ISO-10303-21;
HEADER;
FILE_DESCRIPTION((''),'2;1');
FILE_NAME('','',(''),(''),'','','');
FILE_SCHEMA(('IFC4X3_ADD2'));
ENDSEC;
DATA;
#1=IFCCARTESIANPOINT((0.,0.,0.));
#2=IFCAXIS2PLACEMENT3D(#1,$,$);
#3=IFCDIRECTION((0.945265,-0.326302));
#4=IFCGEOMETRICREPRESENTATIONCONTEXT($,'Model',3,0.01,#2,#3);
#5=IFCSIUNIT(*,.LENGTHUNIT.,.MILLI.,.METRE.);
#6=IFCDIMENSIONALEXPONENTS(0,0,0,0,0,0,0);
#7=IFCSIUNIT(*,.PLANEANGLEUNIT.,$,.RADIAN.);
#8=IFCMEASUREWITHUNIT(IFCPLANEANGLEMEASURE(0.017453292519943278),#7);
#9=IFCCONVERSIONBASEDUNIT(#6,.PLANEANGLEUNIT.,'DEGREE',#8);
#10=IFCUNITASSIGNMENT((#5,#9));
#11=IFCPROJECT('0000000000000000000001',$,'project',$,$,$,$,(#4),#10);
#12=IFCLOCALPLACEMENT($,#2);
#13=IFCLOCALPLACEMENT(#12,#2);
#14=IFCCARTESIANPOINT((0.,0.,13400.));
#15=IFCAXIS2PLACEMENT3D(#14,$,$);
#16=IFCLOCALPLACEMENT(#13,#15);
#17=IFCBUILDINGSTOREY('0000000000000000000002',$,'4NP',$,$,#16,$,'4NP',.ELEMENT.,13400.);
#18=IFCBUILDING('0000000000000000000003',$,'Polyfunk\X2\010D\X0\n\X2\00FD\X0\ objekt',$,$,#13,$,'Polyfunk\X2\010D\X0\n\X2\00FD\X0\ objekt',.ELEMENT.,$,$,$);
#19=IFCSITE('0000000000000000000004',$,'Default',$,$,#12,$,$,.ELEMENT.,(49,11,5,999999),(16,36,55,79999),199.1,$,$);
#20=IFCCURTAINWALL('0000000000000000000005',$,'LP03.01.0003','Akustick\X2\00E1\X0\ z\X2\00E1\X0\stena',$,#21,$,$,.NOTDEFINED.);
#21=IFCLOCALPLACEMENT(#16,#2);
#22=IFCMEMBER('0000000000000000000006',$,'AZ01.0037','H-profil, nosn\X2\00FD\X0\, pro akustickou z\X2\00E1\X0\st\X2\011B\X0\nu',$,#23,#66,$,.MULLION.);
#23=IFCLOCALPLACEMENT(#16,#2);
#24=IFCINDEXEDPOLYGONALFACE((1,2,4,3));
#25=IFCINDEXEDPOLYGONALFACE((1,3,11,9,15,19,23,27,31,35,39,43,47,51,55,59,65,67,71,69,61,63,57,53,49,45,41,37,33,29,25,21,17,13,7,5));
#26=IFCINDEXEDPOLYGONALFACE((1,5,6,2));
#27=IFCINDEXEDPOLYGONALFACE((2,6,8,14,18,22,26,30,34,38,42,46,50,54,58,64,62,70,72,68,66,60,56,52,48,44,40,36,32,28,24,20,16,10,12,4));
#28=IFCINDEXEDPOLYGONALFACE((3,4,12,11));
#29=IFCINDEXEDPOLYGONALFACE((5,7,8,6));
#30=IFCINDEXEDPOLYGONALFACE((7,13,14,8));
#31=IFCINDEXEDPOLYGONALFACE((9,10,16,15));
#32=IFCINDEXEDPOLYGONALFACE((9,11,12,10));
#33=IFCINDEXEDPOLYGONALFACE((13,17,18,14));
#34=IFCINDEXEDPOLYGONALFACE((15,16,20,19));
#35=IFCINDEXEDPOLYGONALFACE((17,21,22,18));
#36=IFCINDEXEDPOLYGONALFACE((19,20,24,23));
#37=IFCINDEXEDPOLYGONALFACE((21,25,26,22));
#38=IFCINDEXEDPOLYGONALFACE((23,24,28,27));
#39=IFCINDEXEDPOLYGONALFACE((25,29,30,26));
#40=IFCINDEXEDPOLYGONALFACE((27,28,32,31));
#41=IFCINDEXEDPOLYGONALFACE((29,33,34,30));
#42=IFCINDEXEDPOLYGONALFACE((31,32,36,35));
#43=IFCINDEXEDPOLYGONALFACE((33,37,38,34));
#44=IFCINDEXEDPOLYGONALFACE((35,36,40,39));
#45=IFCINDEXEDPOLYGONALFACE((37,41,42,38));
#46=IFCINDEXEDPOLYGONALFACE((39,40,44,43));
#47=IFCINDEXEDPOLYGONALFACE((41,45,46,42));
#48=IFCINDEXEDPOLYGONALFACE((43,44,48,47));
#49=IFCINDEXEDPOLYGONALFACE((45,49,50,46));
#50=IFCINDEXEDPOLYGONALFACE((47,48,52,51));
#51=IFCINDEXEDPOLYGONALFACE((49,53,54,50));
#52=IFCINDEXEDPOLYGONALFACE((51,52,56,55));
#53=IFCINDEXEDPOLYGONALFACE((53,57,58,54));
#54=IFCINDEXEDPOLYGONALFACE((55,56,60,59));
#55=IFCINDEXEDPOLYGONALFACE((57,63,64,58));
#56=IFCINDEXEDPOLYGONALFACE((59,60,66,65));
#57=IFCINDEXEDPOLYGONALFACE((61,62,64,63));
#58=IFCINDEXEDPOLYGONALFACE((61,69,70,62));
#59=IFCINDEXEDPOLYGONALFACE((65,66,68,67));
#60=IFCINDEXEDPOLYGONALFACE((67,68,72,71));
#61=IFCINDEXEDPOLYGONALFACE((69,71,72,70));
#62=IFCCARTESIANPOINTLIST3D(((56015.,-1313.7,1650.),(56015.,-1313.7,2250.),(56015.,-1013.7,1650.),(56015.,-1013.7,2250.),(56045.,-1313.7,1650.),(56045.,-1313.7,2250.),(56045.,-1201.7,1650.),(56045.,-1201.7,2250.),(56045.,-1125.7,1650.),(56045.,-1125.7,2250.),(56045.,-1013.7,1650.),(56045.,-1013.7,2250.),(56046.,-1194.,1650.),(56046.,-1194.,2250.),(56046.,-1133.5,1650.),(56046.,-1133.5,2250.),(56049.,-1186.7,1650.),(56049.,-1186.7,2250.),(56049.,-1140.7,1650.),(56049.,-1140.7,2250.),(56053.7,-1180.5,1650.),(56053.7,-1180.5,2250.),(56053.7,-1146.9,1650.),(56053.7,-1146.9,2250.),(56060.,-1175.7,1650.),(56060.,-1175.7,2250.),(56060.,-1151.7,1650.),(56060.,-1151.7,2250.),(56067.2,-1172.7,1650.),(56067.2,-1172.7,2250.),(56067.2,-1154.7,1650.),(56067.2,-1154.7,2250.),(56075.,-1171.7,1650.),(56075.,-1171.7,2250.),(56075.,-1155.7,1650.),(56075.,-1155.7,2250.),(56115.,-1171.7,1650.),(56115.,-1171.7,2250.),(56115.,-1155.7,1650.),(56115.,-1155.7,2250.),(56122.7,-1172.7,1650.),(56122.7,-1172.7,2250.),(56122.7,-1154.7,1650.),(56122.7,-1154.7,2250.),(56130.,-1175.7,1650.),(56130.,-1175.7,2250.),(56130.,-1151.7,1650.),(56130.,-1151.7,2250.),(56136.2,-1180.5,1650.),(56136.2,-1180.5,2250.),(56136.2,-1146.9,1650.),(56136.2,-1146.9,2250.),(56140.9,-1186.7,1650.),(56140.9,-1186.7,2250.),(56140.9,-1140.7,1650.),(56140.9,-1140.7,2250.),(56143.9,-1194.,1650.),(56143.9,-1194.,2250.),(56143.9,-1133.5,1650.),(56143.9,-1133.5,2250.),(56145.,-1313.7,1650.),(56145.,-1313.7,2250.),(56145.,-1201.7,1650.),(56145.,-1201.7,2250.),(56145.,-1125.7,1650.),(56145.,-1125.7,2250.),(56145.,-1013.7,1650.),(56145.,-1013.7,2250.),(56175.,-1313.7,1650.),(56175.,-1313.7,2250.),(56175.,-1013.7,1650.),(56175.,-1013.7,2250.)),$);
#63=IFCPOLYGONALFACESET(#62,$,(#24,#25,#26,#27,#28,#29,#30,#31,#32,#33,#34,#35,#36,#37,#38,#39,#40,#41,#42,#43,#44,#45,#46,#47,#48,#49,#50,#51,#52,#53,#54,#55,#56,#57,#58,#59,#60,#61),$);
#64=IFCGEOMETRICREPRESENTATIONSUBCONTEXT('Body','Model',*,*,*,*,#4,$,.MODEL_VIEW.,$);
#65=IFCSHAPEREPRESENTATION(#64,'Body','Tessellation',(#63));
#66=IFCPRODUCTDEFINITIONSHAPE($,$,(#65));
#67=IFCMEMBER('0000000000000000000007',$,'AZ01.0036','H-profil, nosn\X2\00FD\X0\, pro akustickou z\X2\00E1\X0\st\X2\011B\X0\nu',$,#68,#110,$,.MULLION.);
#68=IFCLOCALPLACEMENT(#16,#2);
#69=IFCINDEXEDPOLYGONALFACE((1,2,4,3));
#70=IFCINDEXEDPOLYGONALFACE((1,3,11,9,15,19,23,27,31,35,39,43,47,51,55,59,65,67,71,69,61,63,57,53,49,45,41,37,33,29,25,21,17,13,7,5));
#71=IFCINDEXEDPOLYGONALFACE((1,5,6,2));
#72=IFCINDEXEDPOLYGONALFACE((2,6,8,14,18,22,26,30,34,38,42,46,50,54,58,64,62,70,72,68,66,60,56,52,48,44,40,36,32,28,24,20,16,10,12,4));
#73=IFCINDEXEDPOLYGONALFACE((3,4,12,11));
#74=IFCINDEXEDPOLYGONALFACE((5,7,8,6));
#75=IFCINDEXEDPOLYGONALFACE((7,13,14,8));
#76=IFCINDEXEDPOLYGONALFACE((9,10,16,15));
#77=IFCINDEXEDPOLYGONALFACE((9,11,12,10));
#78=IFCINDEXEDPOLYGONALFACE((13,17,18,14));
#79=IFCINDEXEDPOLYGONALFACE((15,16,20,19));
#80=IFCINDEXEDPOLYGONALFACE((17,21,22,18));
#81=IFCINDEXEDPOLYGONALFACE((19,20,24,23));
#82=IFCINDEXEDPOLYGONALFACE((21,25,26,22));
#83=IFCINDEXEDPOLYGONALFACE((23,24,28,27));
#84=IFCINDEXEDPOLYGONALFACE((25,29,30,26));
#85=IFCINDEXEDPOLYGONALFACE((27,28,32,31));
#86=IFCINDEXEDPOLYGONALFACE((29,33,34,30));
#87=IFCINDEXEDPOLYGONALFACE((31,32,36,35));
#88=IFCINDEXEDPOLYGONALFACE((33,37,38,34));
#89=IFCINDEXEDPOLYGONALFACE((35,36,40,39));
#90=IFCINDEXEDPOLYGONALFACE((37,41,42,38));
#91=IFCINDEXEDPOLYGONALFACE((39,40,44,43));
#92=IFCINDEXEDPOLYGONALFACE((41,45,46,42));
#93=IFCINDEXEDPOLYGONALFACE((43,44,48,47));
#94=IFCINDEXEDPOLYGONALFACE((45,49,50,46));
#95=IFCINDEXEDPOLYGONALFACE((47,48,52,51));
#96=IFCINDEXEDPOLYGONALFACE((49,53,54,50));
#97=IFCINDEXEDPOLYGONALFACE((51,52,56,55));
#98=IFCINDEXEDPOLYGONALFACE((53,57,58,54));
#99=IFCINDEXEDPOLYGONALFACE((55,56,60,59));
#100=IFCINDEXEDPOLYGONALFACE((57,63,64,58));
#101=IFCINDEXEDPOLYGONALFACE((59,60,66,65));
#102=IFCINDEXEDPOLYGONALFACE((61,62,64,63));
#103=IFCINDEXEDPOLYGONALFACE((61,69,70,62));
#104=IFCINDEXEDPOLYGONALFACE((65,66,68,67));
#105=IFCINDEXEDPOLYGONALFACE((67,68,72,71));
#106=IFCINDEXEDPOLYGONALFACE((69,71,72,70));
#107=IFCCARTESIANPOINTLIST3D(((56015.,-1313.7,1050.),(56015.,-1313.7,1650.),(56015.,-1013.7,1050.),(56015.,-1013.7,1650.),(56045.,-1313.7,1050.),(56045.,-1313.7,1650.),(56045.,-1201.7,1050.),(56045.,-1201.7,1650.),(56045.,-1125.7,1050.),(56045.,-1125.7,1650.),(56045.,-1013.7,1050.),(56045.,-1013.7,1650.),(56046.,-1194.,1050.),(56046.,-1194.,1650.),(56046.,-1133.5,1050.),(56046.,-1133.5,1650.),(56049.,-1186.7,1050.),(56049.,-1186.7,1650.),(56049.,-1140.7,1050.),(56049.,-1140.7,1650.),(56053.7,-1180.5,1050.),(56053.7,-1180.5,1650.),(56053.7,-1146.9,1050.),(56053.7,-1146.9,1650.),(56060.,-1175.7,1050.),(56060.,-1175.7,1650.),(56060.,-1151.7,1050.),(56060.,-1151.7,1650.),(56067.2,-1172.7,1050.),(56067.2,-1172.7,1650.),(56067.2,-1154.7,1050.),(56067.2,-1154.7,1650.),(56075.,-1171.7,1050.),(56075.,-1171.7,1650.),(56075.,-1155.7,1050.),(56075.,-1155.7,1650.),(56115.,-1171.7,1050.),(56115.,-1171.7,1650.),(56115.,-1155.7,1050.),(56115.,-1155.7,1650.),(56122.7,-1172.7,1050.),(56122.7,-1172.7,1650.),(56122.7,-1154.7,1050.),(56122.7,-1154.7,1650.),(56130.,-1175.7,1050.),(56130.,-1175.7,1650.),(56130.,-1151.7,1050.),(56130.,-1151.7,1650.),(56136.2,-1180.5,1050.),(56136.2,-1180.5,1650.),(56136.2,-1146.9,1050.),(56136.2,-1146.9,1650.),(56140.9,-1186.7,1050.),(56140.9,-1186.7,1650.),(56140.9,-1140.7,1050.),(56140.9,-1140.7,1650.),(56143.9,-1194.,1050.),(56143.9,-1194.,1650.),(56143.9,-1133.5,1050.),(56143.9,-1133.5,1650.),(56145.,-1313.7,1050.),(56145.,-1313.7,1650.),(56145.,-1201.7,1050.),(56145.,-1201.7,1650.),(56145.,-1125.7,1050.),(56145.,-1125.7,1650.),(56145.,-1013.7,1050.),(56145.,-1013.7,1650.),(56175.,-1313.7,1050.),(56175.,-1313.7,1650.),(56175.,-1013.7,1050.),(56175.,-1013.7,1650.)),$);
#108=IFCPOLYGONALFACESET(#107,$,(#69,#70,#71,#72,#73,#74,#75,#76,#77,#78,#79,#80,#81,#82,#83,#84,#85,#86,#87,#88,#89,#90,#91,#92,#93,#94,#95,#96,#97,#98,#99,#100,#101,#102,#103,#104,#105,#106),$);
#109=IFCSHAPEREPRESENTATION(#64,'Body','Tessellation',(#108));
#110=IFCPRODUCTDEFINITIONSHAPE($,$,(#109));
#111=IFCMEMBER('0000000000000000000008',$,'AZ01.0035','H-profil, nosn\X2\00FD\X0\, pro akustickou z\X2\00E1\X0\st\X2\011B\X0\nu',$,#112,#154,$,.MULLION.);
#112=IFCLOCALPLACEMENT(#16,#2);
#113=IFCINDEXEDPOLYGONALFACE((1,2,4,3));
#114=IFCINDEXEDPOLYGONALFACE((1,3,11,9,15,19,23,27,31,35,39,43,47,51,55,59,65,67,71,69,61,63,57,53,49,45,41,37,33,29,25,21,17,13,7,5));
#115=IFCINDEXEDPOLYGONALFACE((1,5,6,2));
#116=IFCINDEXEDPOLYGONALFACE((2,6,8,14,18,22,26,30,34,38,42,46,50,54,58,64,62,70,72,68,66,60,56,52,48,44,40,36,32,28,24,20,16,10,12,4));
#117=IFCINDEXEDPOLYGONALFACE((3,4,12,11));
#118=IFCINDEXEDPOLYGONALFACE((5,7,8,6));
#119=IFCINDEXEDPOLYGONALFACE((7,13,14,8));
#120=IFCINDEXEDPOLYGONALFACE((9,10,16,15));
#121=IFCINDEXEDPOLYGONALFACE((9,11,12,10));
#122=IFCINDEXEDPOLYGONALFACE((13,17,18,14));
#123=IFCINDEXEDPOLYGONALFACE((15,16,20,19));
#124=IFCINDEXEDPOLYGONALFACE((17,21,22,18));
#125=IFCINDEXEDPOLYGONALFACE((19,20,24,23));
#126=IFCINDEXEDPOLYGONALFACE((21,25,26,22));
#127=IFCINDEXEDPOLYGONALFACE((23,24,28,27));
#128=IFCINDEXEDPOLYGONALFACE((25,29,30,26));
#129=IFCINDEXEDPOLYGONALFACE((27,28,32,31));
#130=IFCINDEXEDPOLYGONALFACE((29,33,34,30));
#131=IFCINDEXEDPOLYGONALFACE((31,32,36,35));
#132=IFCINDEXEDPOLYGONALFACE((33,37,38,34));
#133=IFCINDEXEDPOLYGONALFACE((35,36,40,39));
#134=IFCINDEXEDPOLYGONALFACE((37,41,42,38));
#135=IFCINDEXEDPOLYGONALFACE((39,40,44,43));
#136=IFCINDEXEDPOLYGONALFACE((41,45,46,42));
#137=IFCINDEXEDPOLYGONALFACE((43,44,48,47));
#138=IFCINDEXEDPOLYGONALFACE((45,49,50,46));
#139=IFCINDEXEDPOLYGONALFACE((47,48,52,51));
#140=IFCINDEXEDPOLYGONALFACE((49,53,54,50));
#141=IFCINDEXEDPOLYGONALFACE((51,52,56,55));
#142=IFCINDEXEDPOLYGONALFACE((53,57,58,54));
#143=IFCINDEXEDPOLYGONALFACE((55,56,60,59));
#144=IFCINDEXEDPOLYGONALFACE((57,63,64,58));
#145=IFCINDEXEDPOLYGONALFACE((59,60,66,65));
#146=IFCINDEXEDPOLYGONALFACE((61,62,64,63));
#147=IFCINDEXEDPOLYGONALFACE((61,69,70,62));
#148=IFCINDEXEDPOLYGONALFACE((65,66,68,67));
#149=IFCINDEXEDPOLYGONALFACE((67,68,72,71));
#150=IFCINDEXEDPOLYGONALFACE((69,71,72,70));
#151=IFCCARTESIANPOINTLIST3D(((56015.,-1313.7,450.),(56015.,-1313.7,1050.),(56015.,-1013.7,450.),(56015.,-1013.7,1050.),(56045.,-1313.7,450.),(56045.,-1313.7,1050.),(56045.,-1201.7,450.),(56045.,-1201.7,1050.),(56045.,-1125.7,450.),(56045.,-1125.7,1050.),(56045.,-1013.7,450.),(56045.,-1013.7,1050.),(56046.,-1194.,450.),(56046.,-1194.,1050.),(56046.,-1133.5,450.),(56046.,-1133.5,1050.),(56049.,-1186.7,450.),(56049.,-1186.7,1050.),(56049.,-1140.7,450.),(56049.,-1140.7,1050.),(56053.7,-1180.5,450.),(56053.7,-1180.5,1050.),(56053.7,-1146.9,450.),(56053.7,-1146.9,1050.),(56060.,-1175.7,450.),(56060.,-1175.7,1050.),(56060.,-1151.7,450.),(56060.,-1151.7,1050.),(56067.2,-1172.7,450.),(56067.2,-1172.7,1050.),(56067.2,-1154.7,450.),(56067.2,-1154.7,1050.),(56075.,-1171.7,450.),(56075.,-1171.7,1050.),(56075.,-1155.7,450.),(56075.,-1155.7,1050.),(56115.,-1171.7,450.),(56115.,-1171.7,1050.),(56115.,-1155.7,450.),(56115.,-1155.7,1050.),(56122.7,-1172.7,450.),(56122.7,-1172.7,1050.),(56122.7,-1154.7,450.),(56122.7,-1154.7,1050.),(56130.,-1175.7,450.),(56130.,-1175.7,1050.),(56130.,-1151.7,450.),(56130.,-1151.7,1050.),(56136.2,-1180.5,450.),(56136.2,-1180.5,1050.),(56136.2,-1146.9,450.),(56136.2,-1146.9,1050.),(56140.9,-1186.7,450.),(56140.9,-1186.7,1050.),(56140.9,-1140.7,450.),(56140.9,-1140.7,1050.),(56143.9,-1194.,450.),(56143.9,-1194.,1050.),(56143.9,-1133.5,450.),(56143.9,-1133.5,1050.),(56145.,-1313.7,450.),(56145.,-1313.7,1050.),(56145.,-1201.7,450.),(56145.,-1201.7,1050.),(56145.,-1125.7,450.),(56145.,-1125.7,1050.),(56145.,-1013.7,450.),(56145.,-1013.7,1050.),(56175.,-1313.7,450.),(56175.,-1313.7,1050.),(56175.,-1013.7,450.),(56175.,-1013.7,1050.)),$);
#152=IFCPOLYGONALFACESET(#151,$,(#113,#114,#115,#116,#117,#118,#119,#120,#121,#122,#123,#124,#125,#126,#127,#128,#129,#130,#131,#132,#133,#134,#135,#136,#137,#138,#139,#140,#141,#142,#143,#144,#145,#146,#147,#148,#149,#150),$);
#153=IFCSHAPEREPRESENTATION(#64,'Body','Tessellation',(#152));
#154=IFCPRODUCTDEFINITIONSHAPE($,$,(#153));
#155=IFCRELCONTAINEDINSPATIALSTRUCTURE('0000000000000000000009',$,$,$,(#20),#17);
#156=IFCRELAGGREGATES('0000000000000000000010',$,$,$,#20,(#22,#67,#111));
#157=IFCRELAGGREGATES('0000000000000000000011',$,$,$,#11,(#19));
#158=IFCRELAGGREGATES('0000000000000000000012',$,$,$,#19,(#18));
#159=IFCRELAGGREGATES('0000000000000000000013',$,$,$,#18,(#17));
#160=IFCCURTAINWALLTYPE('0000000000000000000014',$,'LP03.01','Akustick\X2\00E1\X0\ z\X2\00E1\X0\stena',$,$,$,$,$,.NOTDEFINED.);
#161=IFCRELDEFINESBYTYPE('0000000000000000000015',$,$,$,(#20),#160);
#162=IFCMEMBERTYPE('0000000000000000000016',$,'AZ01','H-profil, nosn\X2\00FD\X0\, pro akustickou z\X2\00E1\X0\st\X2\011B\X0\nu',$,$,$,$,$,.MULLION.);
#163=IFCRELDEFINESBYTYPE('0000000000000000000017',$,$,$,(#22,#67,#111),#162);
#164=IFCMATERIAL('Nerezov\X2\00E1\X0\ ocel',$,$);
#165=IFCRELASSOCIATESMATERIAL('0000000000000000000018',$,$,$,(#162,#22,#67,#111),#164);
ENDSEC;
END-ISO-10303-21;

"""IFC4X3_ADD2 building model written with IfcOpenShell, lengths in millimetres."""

from ifc_helpers import new_model, entity, si_unit, converted_unit, direction, frame, frame_2d, origin, place, context, subcontext, project, spatial, polyline, circle_curve, parameter, trimmed, segment, composite_curve, outline, extrude, source, transform, mapped, material, material_profile, profile_set, profile_usage, type_object, element, aggregate, save


model = new_model("IFC4X3_ADD2")

# Units and contexts
model_context = context("Model", 3, precision=0.01, world=origin(), true_north=direction((0.945265, -0.326302)))
body_context = subcontext(model_context, "Body", "Model", "MODEL_VIEW")
ifc_project = project(units=[si_unit("LENGTHUNIT", "METRE", prefix="MILLI"), converted_unit("PLANEANGLEUNIT", "DEGREE", entity("IfcPlaneAngleMeasure", 0.017453292519943278), si_unit("PLANEANGLEUNIT", "RADIAN"), dimensions=[0, 0, 0, 0, 0, 0, 0])], contexts=[model_context])

# Site, building, storey
site_placement = place(None, origin())
site = spatial("IfcSite", under=ifc_project, at=site_placement, Name="Default", CompositionType="ELEMENT", RefLatitude=(49, 11, 5, 999999), RefLongitude=(16, 36, 55, 79999), RefElevation=199.1)
building_placement = place(site_placement, origin())
building = spatial("IfcBuilding", under=site, at=building_placement, Name="Polyfunkčný objekt", LongName="Polyfunkčný objekt", CompositionType="ELEMENT")
storey_placement = place(building_placement, frame((0.0, 0.0, 13400.0)))
storey = spatial("IfcBuildingStorey", under=building, at=storey_placement, Name="4NP", LongName="4NP", CompositionType="ELEMENT", Elevation=13400.0)

# Curtain wall, members
curtain_wall_type = type_object("IfcCurtainWallType", Name="LP03.01", Description="Akustická zástena", PredefinedType="NOTDEFINED")
curtain_wall_1_placement = place(storey_placement, frame((0.0, 0.0, -13400.0)))
curtain_wall_1 = element("IfcCurtainWall", 1, at=curtain_wall_1_placement, inside=storey, type_object=curtain_wall_type, Name="LP03.01.0003", Description="Akustická zástena", PredefinedType="NOTDEFINED")
ifc_material_1 = material(Name="Nerezová ocel")
ifc_material_profile = material_profile(ifc_material_1, outline(composite_curve([segment(polyline([(50.0, -150.0), (80.0, -150.0)]), True, "CONTINUOUS"), segment(polyline([(80.0, -150.0), (80.0, 150.0)]), True, "CONTINUOUS"), segment(polyline([(80.0, 150.0), (50.0, 150.0)]), True, "CONTINUOUS"), segment(polyline([(50.0, 150.0), (50.0, 38.0)]), True, "CONTINUOUS"), segment(trimmed(circle_curve(frame_2d((20.0, 38.0), x_axis=(0.0, 1.0)), 30.0), [parameter(180.0)], [parameter(270.0)], True, "PARAMETER"), False, "CONTINUOUS"), segment(polyline([(20.0, 8.0), (-20.0, 8.0)]), True, "CONTINUOUS"), segment(trimmed(circle_curve(frame_2d((-20.0, 38.0), x_axis=(0.0, 1.0)), 30.0), [parameter(90.0)], [parameter(180.0)], True, "PARAMETER"), False, "CONTINUOUS"), segment(polyline([(-50.0, 38.0), (-50.0, 150.0)]), True, "CONTINUOUS"), segment(polyline([(-50.0, 150.0), (-80.0, 150.0)]), True, "CONTINUOUS"), segment(polyline([(-80.0, 150.0), (-80.0, -150.0)]), True, "CONTINUOUS"), segment(polyline([(-80.0, -150.0), (-50.0, -150.0)]), True, "CONTINUOUS"), segment(polyline([(-50.0, -150.0), (-50.0, -38.0)]), True, "CONTINUOUS"), segment(trimmed(circle_curve(frame_2d((-20.0, -38.0), x_axis=(0.0, 1.0)), 30.0), [parameter(0.0)], [parameter(90.0)], True, "PARAMETER"), False, "CONTINUOUS"), segment(polyline([(-20.0, -8.0), (20.0, -8.0)]), True, "CONTINUOUS"), segment(trimmed(circle_curve(frame_2d((20.0, -38.0), x_axis=(0.0, 1.0)), 30.0), [parameter(270.0)], [parameter(0.0)], True, "PARAMETER"), False, "CONTINUOUS"), segment(polyline([(50.0, -38.0), (50.0, -150.0)]), True, "CONTINUOUS")], self_intersect=False)), Name="Profil zástena")
ifc_profile_set = profile_set([ifc_material_profile], Name="Profil zástena")
ifc_profile_usage = profile_usage(ifc_profile_set)
member_type = type_object("IfcMemberType", Name="AZ01", Description="H-profil, nosný, pro akustickou zástěnu", PredefinedType="MULLION", material=ifc_profile_set)
shared_shape_1 = source(origin(), body_context, "Body", "SweptSolid", [
    extrude(outline(composite_curve([segment(polyline([(50.0, -150.0), (80.0, -150.0)]), True, "CONTINUOUS"), segment(polyline([(80.0, -150.0), (80.0, 150.0)]), True, "CONTINUOUS"), segment(polyline([(80.0, 150.0), (50.0, 150.0)]), True, "CONTINUOUS"), segment(polyline([(50.0, 150.0), (50.0, 38.0)]), True, "CONTINUOUS"), segment(trimmed(circle_curve(frame_2d((20.0, 38.0), x_axis=(0.0, 1.0)), 30.0), [parameter(180.0)], [parameter(270.0)], True, "PARAMETER"), False, "CONTINUOUS"), segment(polyline([(20.0, 8.0), (-20.0, 8.0)]), True, "CONTINUOUS"), segment(trimmed(circle_curve(frame_2d((-20.0, 38.0), x_axis=(0.0, 1.0)), 30.0), [parameter(90.0)], [parameter(180.0)], True, "PARAMETER"), False, "CONTINUOUS"), segment(polyline([(-50.0, 38.0), (-50.0, 150.0)]), True, "CONTINUOUS"), segment(polyline([(-50.0, 150.0), (-80.0, 150.0)]), True, "CONTINUOUS"), segment(polyline([(-80.0, 150.0), (-80.0, -150.0)]), True, "CONTINUOUS"), segment(polyline([(-80.0, -150.0), (-50.0, -150.0)]), True, "CONTINUOUS"), segment(polyline([(-50.0, -150.0), (-50.0, -38.0)]), True, "CONTINUOUS"), segment(trimmed(circle_curve(frame_2d((-20.0, -38.0), x_axis=(0.0, 1.0)), 30.0), [parameter(0.0)], [parameter(90.0)], True, "PARAMETER"), False, "CONTINUOUS"), segment(polyline([(-20.0, -8.0), (20.0, -8.0)]), True, "CONTINUOUS"), segment(trimmed(circle_curve(frame_2d((20.0, -38.0), x_axis=(0.0, 1.0)), 30.0), [parameter(270.0)], [parameter(0.0)], True, "PARAMETER"), False, "CONTINUOUS"), segment(polyline([(50.0, -38.0), (50.0, -150.0)]), True, "CONTINUOUS")], self_intersect=False)), frame((-150.0, 0.0, -600.0), z_axis=(0.0, 0.0, 1.0), x_axis=(0.0, 1.0, 0.0)), (0.0, 0.0, 1.0), 600.0),
])
member_1_placement = place(curtain_wall_1_placement, frame((56095.0, -1313.7, 15650.0), z_axis=(0.0, 0.0, 1.0), x_axis=(0.0, -1.0, 0.0)))
member_1 = element("IfcMember", 2, at=member_1_placement, type_object=member_type, material=ifc_profile_usage, Name="AZ01.0037", Description="H-profil, nosný, pro akustickou zástěnu", PredefinedType="MULLION", context=body_context, shape_type="MappedRepresentation", body=[
    mapped(shared_shape_1, transform((0.0, 0.0, 0.0), scale=1.0)),
])
member_2_placement = place(curtain_wall_1_placement, frame((56095.0, -1313.7, 15050.0), z_axis=(0.0, 0.0, 1.0), x_axis=(0.0, -1.0, 0.0)))
member_2 = element("IfcMember", 3, at=member_2_placement, type_object=member_type, material=ifc_profile_usage, Name="AZ01.0036", Description="H-profil, nosný, pro akustickou zástěnu", PredefinedType="MULLION", context=body_context, shape_type="MappedRepresentation", body=[
    mapped(shared_shape_1, transform((0.0, 0.0, 0.0), scale=1.0)),
])
member_3_placement = place(curtain_wall_1_placement, frame((56095.0, -1313.7, 14450.0), z_axis=(0.0, 0.0, 1.0), x_axis=(0.0, -1.0, 0.0)))
member_3 = element("IfcMember", 4, at=member_3_placement, type_object=member_type, material=ifc_profile_usage, Name="AZ01.0035", Description="H-profil, nosný, pro akustickou zástěnu", PredefinedType="MULLION", context=body_context, shape_type="MappedRepresentation", body=[
    mapped(shared_shape_1, transform((0.0, 0.0, 0.0), scale=1.0)),
])

aggregate(curtain_wall_1, [member_1, member_2, member_3])

save(model, "model.ifc")
